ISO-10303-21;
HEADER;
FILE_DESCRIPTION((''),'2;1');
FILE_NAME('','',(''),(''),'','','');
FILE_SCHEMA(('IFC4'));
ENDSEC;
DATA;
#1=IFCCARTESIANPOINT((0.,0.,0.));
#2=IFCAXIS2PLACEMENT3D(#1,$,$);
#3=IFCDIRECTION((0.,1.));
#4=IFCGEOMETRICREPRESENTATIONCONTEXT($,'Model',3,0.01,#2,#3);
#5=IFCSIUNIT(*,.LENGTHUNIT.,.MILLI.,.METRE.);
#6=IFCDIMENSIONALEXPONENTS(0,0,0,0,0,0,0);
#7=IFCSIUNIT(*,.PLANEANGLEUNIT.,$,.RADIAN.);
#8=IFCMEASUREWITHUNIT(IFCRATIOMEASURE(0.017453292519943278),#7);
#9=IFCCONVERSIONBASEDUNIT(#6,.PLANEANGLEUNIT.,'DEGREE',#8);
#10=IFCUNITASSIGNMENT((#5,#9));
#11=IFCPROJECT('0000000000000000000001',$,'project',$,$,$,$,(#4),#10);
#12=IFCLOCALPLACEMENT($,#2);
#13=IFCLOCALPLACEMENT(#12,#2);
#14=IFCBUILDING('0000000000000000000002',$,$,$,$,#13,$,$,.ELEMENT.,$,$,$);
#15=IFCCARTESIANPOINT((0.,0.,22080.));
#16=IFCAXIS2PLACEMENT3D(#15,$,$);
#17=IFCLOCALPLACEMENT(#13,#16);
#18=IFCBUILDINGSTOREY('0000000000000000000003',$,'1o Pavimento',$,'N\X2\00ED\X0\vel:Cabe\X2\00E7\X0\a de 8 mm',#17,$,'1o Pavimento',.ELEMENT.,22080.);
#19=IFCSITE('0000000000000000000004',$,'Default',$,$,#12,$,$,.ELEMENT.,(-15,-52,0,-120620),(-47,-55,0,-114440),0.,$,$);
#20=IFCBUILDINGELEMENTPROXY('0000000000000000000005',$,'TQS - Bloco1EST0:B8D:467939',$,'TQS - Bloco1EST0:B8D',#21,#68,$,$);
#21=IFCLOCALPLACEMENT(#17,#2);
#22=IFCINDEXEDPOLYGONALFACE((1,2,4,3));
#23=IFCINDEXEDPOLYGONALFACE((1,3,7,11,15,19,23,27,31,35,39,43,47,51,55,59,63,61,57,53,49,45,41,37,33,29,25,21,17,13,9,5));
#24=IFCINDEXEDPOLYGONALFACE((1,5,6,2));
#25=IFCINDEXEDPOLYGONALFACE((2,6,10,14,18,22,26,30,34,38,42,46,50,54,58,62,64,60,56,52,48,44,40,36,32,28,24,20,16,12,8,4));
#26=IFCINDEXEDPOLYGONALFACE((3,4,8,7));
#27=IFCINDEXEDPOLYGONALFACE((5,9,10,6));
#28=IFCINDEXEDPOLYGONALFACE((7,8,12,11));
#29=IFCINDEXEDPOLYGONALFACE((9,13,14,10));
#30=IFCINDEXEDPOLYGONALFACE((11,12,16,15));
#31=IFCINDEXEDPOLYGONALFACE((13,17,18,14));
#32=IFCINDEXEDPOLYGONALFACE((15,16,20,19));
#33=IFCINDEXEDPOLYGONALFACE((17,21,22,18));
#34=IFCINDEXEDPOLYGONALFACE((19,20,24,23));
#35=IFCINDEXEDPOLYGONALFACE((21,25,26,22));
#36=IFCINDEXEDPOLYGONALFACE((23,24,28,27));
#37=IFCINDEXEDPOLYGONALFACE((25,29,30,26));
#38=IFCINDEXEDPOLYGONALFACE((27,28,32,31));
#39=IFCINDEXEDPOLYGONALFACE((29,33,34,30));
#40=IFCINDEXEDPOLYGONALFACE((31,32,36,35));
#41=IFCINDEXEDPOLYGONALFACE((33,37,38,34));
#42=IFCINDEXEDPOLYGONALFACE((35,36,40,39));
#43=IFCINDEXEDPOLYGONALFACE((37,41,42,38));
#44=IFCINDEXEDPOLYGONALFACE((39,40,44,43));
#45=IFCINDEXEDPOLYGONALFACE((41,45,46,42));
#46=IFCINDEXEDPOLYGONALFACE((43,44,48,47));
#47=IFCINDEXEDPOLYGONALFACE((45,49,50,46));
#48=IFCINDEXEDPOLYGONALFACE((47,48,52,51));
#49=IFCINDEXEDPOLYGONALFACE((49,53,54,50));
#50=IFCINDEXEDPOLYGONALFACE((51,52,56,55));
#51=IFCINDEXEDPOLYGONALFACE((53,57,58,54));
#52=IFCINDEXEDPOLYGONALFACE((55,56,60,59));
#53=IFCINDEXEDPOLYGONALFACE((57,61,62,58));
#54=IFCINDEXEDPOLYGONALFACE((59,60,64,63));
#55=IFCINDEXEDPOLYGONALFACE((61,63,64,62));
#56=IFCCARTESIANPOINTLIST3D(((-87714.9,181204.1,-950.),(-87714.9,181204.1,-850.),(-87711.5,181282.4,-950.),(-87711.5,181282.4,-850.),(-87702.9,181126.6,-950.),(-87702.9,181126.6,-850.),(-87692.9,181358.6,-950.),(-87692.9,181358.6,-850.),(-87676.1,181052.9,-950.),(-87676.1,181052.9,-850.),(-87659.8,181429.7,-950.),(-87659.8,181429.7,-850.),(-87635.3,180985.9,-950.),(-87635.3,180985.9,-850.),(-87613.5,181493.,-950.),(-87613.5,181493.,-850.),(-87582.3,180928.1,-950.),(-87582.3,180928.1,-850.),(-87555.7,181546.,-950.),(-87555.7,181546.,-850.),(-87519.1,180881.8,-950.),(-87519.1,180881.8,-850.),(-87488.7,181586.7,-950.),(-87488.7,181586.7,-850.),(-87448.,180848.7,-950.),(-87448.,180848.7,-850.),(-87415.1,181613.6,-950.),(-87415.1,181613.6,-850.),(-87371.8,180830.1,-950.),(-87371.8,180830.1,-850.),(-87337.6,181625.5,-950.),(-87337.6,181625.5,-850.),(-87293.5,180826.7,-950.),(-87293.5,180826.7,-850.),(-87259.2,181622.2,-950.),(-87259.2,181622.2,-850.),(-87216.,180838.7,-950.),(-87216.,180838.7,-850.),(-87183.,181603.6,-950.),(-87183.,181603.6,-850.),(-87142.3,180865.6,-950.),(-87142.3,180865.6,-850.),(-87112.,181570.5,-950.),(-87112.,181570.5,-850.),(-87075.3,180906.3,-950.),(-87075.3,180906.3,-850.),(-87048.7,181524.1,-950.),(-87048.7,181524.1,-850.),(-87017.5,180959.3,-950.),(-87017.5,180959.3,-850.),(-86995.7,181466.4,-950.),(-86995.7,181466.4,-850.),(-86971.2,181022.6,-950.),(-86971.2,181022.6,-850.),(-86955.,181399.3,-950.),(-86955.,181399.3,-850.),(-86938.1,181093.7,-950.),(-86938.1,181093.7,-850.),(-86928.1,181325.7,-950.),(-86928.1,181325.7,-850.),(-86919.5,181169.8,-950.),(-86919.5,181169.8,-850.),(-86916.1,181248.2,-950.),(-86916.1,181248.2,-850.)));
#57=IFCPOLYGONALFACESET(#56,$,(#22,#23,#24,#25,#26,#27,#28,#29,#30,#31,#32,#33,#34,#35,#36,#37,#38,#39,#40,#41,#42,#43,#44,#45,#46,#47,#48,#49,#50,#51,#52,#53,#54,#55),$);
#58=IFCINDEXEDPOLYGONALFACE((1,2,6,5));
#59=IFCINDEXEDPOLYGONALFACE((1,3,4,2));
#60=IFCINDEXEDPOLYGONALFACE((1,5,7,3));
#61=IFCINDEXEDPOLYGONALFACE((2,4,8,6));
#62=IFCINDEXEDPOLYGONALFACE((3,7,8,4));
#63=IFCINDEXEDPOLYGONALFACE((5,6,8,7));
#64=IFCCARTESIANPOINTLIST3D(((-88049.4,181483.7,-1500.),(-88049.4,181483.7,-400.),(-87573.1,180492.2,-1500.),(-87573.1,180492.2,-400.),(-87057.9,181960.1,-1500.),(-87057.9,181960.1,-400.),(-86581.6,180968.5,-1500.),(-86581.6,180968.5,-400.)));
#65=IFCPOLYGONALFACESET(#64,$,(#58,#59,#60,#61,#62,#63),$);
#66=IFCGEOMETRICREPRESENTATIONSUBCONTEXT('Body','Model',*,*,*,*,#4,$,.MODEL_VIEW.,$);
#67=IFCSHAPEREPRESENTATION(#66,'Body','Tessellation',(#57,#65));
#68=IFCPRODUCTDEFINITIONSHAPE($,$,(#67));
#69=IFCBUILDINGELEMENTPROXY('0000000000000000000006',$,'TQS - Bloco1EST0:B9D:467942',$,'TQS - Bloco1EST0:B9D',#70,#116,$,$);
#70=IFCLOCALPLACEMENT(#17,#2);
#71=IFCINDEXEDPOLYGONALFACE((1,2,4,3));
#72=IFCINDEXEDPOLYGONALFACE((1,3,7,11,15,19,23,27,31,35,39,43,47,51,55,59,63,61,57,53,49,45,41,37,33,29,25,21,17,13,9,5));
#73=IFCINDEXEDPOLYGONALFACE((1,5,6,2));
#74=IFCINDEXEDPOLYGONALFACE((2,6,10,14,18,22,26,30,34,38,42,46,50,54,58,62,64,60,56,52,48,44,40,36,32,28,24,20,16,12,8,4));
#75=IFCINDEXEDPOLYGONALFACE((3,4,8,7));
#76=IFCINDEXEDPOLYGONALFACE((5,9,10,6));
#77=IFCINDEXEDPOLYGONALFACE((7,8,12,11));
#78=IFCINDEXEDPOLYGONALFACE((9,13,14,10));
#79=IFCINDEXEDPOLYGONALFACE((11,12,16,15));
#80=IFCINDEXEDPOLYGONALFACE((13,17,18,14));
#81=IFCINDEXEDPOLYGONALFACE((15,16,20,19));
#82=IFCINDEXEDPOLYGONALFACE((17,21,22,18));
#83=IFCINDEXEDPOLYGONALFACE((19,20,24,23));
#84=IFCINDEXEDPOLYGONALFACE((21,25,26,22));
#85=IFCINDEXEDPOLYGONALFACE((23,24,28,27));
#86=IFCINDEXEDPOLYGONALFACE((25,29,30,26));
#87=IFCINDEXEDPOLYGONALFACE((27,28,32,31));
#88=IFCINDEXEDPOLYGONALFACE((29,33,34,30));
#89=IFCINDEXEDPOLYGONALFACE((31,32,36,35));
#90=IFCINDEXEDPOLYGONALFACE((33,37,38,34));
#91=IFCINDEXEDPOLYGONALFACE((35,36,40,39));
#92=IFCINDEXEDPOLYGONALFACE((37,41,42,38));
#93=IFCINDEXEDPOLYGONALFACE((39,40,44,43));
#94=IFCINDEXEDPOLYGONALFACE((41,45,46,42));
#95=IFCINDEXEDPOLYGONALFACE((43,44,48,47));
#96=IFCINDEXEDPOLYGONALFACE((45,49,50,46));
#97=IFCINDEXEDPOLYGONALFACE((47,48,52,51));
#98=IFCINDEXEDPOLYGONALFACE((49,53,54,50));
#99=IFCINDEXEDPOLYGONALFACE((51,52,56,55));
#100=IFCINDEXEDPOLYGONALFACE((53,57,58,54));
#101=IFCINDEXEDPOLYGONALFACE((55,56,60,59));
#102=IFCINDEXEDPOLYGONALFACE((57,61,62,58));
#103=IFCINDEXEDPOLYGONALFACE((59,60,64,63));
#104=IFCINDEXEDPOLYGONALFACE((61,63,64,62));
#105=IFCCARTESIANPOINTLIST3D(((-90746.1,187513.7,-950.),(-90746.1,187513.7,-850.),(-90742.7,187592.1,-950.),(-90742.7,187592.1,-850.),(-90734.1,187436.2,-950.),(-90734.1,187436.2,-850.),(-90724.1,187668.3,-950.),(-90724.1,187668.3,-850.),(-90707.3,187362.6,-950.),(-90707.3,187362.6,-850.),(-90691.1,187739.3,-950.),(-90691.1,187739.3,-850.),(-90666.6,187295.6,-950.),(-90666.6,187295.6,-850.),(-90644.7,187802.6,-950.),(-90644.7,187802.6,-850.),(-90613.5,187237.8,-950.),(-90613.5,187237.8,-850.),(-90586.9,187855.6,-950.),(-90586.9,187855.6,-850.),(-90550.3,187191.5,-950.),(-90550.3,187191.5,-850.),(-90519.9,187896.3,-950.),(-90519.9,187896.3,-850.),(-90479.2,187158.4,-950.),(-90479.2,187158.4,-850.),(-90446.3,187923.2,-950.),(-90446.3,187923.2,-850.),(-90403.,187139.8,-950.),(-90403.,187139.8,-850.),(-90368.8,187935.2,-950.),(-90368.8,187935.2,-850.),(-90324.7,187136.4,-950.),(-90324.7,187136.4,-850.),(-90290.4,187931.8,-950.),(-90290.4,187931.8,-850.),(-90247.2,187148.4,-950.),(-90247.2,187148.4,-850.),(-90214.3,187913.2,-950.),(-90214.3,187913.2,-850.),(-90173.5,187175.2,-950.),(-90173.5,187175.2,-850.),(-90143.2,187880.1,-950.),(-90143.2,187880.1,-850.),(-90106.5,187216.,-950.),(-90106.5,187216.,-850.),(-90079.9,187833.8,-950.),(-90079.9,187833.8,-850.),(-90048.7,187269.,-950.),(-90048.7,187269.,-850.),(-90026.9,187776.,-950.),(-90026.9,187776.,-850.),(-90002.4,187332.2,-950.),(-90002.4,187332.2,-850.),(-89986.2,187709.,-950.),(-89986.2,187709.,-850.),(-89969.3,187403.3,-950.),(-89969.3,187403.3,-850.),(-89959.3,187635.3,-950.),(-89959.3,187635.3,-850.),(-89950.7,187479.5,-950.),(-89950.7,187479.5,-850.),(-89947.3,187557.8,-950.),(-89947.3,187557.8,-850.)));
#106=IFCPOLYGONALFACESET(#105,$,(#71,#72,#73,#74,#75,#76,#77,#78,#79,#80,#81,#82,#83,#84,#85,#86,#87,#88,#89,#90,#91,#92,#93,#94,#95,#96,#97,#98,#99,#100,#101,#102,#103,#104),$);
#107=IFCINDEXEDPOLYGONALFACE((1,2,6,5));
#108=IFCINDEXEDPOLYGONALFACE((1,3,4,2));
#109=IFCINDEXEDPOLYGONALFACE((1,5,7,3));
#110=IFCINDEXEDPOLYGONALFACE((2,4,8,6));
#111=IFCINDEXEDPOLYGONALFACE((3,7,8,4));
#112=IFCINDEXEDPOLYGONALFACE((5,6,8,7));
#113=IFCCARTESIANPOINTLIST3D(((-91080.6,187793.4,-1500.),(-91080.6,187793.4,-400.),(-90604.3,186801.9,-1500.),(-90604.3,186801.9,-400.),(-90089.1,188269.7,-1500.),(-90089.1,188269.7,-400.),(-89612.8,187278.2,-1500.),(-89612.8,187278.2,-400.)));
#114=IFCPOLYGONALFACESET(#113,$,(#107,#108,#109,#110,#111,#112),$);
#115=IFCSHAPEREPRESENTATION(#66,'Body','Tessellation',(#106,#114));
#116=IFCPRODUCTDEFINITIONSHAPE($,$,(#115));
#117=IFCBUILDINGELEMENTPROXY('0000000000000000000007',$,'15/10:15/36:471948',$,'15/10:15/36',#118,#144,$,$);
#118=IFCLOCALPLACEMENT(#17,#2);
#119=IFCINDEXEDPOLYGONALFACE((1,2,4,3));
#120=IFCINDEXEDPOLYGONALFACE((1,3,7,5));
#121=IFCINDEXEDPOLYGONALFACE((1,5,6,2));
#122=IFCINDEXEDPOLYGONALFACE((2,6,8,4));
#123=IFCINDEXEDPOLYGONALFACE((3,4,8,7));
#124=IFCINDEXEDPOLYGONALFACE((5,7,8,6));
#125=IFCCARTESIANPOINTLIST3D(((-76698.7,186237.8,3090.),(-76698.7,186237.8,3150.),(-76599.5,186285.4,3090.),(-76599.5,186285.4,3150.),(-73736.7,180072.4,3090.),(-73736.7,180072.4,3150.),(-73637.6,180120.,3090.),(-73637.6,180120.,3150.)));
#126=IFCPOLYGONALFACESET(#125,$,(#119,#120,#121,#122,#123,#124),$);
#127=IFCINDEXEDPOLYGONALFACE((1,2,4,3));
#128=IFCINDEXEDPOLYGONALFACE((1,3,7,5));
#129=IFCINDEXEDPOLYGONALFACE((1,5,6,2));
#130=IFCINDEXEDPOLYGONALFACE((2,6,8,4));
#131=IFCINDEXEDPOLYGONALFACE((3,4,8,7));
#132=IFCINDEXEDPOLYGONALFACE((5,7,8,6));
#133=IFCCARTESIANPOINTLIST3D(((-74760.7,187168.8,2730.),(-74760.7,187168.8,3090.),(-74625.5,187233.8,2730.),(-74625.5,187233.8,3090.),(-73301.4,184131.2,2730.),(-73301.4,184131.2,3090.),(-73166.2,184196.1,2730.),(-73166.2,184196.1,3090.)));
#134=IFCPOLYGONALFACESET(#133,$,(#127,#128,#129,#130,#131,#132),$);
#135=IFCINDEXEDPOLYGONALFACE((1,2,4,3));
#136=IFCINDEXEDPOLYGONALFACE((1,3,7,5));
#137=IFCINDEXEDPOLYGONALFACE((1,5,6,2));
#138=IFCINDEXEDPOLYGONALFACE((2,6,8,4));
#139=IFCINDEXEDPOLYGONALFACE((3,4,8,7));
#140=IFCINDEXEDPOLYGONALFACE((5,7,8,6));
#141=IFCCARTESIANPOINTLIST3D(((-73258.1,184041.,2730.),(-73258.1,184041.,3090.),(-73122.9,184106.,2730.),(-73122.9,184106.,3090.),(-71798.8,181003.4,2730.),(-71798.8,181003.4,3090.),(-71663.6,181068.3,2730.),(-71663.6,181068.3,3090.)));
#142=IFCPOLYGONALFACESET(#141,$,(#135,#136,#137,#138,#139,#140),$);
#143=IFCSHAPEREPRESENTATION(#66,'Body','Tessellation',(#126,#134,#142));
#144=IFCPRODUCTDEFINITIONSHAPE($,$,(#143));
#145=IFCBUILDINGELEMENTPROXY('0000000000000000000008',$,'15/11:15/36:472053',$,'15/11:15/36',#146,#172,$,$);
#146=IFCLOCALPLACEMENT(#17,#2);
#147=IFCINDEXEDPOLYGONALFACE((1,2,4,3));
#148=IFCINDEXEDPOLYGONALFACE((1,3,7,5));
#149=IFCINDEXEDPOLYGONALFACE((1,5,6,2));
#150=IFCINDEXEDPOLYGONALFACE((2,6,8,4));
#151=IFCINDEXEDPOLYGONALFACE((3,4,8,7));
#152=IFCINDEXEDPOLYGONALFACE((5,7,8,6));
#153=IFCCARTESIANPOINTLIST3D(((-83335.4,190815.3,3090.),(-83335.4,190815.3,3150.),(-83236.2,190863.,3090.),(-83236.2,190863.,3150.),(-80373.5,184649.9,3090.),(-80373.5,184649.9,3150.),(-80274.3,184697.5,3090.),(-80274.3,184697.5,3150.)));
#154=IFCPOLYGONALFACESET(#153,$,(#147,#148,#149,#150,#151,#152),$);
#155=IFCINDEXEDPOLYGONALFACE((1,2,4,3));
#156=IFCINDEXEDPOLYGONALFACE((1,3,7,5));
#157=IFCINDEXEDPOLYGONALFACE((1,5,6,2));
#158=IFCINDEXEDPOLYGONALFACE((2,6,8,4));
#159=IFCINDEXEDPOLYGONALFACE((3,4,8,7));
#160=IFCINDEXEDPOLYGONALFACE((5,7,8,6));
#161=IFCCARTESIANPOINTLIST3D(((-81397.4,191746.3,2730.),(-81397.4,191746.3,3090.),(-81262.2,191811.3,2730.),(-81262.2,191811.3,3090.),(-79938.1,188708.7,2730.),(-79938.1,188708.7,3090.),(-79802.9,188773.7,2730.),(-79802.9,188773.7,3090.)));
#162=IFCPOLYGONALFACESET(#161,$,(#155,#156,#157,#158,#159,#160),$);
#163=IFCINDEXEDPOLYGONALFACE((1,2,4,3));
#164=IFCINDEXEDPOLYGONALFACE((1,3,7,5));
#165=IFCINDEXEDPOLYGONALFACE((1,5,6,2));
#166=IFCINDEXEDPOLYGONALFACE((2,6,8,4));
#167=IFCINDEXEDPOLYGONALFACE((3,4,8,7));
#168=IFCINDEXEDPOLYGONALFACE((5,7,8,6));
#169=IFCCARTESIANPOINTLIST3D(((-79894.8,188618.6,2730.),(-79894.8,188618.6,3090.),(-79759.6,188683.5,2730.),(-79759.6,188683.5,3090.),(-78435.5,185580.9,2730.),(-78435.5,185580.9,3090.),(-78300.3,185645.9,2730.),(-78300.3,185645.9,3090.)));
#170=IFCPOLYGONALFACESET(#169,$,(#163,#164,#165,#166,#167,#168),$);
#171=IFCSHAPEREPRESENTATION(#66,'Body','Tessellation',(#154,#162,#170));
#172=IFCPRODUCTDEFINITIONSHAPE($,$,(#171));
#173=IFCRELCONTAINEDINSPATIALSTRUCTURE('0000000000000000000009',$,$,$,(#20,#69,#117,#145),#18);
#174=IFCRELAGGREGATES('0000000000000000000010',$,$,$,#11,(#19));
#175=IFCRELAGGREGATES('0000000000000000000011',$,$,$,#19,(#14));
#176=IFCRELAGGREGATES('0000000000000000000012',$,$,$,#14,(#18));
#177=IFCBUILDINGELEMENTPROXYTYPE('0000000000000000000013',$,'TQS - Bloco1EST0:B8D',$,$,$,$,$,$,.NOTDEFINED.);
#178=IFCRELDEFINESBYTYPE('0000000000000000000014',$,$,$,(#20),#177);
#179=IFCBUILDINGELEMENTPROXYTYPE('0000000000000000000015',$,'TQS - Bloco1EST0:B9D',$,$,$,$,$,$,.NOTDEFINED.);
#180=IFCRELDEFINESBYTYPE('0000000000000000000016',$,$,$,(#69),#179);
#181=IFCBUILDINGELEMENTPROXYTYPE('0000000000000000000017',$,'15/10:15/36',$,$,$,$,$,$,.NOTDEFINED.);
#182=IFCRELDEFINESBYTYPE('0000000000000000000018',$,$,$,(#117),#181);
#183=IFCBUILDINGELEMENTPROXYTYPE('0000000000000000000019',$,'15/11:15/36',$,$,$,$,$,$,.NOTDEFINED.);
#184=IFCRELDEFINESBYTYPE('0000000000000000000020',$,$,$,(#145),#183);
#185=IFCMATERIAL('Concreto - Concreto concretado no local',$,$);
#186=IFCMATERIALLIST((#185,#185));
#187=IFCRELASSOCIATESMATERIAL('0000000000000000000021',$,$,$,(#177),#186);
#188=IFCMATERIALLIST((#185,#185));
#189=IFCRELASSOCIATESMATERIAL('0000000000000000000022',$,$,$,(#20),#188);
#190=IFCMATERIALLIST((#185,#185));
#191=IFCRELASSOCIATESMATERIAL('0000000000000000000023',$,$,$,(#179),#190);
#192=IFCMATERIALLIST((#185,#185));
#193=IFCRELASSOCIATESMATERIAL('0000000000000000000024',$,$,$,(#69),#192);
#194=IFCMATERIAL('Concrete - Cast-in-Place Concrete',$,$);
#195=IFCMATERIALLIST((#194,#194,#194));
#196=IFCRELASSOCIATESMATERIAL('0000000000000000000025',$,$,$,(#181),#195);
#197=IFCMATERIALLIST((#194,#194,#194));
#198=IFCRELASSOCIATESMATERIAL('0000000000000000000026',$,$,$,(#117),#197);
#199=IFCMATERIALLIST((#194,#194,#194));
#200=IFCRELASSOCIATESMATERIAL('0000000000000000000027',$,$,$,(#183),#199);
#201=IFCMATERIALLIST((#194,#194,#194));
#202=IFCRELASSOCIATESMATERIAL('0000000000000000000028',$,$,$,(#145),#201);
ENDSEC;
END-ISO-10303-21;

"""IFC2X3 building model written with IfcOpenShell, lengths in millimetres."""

from ifc_helpers import new_model, entity, si_unit, converted_unit, direction, frame, frame_2d, origin, origin_2d_with_axis, place, context, subcontext, project, spatial, rectangle, circle, extrude, source, transform, mapped, material, material_list, type_object, type_shapes, element, save


model = new_model("IFC2X3")

# Units and contexts
model_context = context("Model", 3, precision=0.01, world=origin(), true_north=direction((0.0, 1.0)))
body_context = subcontext(model_context, "Body", "Model", "MODEL_VIEW")
ifc_project = project(units=[si_unit("LENGTHUNIT", "METRE", prefix="MILLI"), converted_unit("PLANEANGLEUNIT", "DEGREE", entity("IfcRatioMeasure", 0.017453292519943278), si_unit("PLANEANGLEUNIT", "RADIAN"), dimensions=[0, 0, 0, 0, 0, 0, 0])], contexts=[model_context])

# Site, building, storey
site_placement = place(None, origin())
site = spatial("IfcSite", under=ifc_project, at=site_placement, Name="Default", CompositionType="ELEMENT", RefLatitude=(-15, -52, 0, -120620), RefLongitude=(-47, -55, 0, -114440), RefElevation=0.0)
building_placement = place(site_placement, origin())
building = spatial("IfcBuilding", under=site, at=building_placement, CompositionType="ELEMENT")
storey_placement = place(building_placement, frame((0.0, 0.0, 22080.0)))
storey = spatial("IfcBuildingStorey", under=building, at=storey_placement, Name="1o Pavimento", ObjectType="Nível:Cabeça de 8 mm", LongName="1o Pavimento", CompositionType="ELEMENT", Elevation=22080.0)

# Building element proxies
ifc_material_1 = material(Name="Concreto - Concreto concretado no local")
ifc_material_list_1 = material_list([ifc_material_1, ifc_material_1])
ifc_material_list_2 = material_list([ifc_material_1, ifc_material_1])
building_element_proxy_type_1 = type_object("IfcBuildingElementProxyType", Name="TQS - Bloco1EST0:B8D", PredefinedType="NOTDEFINED", material=ifc_material_list_2)
shared_shape_1 = source(origin(), body_context, "Body", "SweptSolid", [
    extrude(circle(Radius=400.0, at=frame_2d((0.0, 0.0), x_axis=(1.0, 0.0))), frame((0.0, 0.0, -550.0)), (0.0, 0.0, 1.0), 100.0),
    extrude(rectangle(XDim=1100.0, YDim=1100.0, at=origin_2d_with_axis()), frame((0.0, 0.0, -1100.0), z_axis=(0.0, 0.0, 1.0), x_axis=(-1.0, 0.0, 0.0)), (0.0, 0.0, 1.0), 1100.0),
])
type_shapes(building_element_proxy_type_1, [shared_shape_1])
proxy_1_placement = place(storey_placement, frame((-87315.5, 181226.1, -400.0), z_axis=(0.0, 0.0, 1.0), x_axis=(-0.43303, 0.90138, 0.0)))
element("IfcBuildingElementProxy", 1, at=proxy_1_placement, inside=storey, type_object=building_element_proxy_type_1, material=ifc_material_list_1, Name="TQS - Bloco1EST0:B8D:467939", ObjectType="TQS - Bloco1EST0:B8D", context=body_context, shape_type="MappedRepresentation", body=[
    mapped(shared_shape_1, transform((0.0, 0.0, 0.0), scale=1.0)),
])
ifc_material_list_3 = material_list([ifc_material_1, ifc_material_1])
ifc_material_list_4 = material_list([ifc_material_1, ifc_material_1])
building_element_proxy_type_2 = type_object("IfcBuildingElementProxyType", Name="TQS - Bloco1EST0:B9D", PredefinedType="NOTDEFINED", material=ifc_material_list_4)
shared_shape_2 = source(origin(), body_context, "Body", "SweptSolid", [
    extrude(circle(Radius=400.0, at=frame_2d((0.0, 0.0), x_axis=(1.0, 0.0))), frame((0.0, 0.0, -550.0)), (0.0, 0.0, 1.0), 100.0),
    extrude(rectangle(XDim=1100.0, YDim=1100.0, at=origin_2d_with_axis()), frame((0.0, 0.0, -1100.0), z_axis=(0.0, 0.0, 1.0), x_axis=(-1.0, 0.0, 0.0)), (0.0, 0.0, 1.0), 1100.0),
])
type_shapes(building_element_proxy_type_2, [shared_shape_2])
proxy_2_placement = place(storey_placement, frame((-90346.7, 187535.8, -400.0), z_axis=(0.0, 0.0, 1.0), x_axis=(-0.43303, 0.90138, 0.0)))
element("IfcBuildingElementProxy", 2, at=proxy_2_placement, inside=storey, type_object=building_element_proxy_type_2, material=ifc_material_list_3, Name="TQS - Bloco1EST0:B9D:467942", ObjectType="TQS - Bloco1EST0:B9D", context=body_context, shape_type="MappedRepresentation", body=[
    mapped(shared_shape_2, transform((0.0, 0.0, 0.0), scale=1.0)),
])
ifc_material_2 = material(Name="Concrete - Cast-in-Place Concrete")
ifc_material_list_5 = material_list([ifc_material_2, ifc_material_2, ifc_material_2])
ifc_material_list_6 = material_list([ifc_material_2, ifc_material_2, ifc_material_2])
building_element_proxy_type_3 = type_object("IfcBuildingElementProxyType", Name="15/10:15/36", PredefinedType="NOTDEFINED", material=ifc_material_list_6)
shared_shape_3 = source(origin(), body_context, "Body", "SweptSolid", [
    extrude(rectangle(XDim=110.0, YDim=6840.0, at=frame_2d((0.0, 0.0), x_axis=(1.0, 0.0))), frame((1530.5, 3106.5, 360.0), z_axis=(0.0, 0.0, 1.0), x_axis=(0.90138, 0.43303, 0.0)), (0.0, 0.0, 1.0), 60.0),
    extrude(rectangle(XDim=3370.0, YDim=150.0, at=frame_2d((0.0, 0.0), x_axis=(1.0, 0.0))), frame((2735.2, 5610.1, 0.0), z_axis=(0.0, 0.0, 1.0), x_axis=(0.43303, -0.90138, 0.0)), (0.0, 0.0, 1.0), 360.0),
    extrude(rectangle(XDim=3370.0, YDim=150.0, at=frame_2d((0.0, 0.0), x_axis=(1.0, 0.0))), frame((4237.8, 2482.3, 0.0), z_axis=(0.0, 0.0, 1.0), x_axis=(0.43303, -0.90138, 0.0)), (0.0, 0.0, 1.0), 360.0),
])
type_shapes(building_element_proxy_type_3, [shared_shape_3])
proxy_3_placement = place(storey_placement, frame((-76698.7, 180072.4, 2730.0)))
element("IfcBuildingElementProxy", 3, at=proxy_3_placement, inside=storey, type_object=building_element_proxy_type_3, material=ifc_material_list_5, Name="15/10:15/36:471948", ObjectType="15/10:15/36", context=body_context, shape_type="MappedRepresentation", body=[
    mapped(shared_shape_3, transform((0.0, 0.0, 0.0), scale=1.0)),
])
ifc_material_list_7 = material_list([ifc_material_2, ifc_material_2, ifc_material_2])
ifc_material_list_8 = material_list([ifc_material_2, ifc_material_2, ifc_material_2])
building_element_proxy_type_4 = type_object("IfcBuildingElementProxyType", Name="15/11:15/36", PredefinedType="NOTDEFINED", material=ifc_material_list_8)
shared_shape_4 = source(origin(), body_context, "Body", "SweptSolid", [
    extrude(rectangle(XDim=110.0, YDim=6840.0, at=frame_2d((0.0, 0.0), x_axis=(1.0, 0.0))), frame((1530.5, 3106.5, 360.0), z_axis=(0.0, 0.0, 1.0), x_axis=(0.90138, 0.43303, 0.0)), (0.0, 0.0, 1.0), 60.0),
    extrude(rectangle(XDim=3370.0, YDim=150.0, at=frame_2d((0.0, 0.0), x_axis=(1.0, 0.0))), frame((2735.2, 5610.1, 0.0), z_axis=(0.0, 0.0, 1.0), x_axis=(0.43303, -0.90138, 0.0)), (0.0, 0.0, 1.0), 360.0),
    extrude(rectangle(XDim=3370.0, YDim=150.0, at=frame_2d((0.0, 0.0), x_axis=(1.0, 0.0))), frame((4237.8, 2482.3, 0.0), z_axis=(0.0, 0.0, 1.0), x_axis=(0.43303, -0.90138, 0.0)), (0.0, 0.0, 1.0), 360.0),
])
type_shapes(building_element_proxy_type_4, [shared_shape_4])
proxy_4_placement = place(storey_placement, frame((-83335.4, 184649.9, 2730.0)))
element("IfcBuildingElementProxy", 4, at=proxy_4_placement, inside=storey, type_object=building_element_proxy_type_4, material=ifc_material_list_7, Name="15/11:15/36:472053", ObjectType="15/11:15/36", context=body_context, shape_type="MappedRepresentation", body=[
    mapped(shared_shape_4, transform((0.0, 0.0, 0.0), scale=1.0)),
])

save(model, "model.ifc")
